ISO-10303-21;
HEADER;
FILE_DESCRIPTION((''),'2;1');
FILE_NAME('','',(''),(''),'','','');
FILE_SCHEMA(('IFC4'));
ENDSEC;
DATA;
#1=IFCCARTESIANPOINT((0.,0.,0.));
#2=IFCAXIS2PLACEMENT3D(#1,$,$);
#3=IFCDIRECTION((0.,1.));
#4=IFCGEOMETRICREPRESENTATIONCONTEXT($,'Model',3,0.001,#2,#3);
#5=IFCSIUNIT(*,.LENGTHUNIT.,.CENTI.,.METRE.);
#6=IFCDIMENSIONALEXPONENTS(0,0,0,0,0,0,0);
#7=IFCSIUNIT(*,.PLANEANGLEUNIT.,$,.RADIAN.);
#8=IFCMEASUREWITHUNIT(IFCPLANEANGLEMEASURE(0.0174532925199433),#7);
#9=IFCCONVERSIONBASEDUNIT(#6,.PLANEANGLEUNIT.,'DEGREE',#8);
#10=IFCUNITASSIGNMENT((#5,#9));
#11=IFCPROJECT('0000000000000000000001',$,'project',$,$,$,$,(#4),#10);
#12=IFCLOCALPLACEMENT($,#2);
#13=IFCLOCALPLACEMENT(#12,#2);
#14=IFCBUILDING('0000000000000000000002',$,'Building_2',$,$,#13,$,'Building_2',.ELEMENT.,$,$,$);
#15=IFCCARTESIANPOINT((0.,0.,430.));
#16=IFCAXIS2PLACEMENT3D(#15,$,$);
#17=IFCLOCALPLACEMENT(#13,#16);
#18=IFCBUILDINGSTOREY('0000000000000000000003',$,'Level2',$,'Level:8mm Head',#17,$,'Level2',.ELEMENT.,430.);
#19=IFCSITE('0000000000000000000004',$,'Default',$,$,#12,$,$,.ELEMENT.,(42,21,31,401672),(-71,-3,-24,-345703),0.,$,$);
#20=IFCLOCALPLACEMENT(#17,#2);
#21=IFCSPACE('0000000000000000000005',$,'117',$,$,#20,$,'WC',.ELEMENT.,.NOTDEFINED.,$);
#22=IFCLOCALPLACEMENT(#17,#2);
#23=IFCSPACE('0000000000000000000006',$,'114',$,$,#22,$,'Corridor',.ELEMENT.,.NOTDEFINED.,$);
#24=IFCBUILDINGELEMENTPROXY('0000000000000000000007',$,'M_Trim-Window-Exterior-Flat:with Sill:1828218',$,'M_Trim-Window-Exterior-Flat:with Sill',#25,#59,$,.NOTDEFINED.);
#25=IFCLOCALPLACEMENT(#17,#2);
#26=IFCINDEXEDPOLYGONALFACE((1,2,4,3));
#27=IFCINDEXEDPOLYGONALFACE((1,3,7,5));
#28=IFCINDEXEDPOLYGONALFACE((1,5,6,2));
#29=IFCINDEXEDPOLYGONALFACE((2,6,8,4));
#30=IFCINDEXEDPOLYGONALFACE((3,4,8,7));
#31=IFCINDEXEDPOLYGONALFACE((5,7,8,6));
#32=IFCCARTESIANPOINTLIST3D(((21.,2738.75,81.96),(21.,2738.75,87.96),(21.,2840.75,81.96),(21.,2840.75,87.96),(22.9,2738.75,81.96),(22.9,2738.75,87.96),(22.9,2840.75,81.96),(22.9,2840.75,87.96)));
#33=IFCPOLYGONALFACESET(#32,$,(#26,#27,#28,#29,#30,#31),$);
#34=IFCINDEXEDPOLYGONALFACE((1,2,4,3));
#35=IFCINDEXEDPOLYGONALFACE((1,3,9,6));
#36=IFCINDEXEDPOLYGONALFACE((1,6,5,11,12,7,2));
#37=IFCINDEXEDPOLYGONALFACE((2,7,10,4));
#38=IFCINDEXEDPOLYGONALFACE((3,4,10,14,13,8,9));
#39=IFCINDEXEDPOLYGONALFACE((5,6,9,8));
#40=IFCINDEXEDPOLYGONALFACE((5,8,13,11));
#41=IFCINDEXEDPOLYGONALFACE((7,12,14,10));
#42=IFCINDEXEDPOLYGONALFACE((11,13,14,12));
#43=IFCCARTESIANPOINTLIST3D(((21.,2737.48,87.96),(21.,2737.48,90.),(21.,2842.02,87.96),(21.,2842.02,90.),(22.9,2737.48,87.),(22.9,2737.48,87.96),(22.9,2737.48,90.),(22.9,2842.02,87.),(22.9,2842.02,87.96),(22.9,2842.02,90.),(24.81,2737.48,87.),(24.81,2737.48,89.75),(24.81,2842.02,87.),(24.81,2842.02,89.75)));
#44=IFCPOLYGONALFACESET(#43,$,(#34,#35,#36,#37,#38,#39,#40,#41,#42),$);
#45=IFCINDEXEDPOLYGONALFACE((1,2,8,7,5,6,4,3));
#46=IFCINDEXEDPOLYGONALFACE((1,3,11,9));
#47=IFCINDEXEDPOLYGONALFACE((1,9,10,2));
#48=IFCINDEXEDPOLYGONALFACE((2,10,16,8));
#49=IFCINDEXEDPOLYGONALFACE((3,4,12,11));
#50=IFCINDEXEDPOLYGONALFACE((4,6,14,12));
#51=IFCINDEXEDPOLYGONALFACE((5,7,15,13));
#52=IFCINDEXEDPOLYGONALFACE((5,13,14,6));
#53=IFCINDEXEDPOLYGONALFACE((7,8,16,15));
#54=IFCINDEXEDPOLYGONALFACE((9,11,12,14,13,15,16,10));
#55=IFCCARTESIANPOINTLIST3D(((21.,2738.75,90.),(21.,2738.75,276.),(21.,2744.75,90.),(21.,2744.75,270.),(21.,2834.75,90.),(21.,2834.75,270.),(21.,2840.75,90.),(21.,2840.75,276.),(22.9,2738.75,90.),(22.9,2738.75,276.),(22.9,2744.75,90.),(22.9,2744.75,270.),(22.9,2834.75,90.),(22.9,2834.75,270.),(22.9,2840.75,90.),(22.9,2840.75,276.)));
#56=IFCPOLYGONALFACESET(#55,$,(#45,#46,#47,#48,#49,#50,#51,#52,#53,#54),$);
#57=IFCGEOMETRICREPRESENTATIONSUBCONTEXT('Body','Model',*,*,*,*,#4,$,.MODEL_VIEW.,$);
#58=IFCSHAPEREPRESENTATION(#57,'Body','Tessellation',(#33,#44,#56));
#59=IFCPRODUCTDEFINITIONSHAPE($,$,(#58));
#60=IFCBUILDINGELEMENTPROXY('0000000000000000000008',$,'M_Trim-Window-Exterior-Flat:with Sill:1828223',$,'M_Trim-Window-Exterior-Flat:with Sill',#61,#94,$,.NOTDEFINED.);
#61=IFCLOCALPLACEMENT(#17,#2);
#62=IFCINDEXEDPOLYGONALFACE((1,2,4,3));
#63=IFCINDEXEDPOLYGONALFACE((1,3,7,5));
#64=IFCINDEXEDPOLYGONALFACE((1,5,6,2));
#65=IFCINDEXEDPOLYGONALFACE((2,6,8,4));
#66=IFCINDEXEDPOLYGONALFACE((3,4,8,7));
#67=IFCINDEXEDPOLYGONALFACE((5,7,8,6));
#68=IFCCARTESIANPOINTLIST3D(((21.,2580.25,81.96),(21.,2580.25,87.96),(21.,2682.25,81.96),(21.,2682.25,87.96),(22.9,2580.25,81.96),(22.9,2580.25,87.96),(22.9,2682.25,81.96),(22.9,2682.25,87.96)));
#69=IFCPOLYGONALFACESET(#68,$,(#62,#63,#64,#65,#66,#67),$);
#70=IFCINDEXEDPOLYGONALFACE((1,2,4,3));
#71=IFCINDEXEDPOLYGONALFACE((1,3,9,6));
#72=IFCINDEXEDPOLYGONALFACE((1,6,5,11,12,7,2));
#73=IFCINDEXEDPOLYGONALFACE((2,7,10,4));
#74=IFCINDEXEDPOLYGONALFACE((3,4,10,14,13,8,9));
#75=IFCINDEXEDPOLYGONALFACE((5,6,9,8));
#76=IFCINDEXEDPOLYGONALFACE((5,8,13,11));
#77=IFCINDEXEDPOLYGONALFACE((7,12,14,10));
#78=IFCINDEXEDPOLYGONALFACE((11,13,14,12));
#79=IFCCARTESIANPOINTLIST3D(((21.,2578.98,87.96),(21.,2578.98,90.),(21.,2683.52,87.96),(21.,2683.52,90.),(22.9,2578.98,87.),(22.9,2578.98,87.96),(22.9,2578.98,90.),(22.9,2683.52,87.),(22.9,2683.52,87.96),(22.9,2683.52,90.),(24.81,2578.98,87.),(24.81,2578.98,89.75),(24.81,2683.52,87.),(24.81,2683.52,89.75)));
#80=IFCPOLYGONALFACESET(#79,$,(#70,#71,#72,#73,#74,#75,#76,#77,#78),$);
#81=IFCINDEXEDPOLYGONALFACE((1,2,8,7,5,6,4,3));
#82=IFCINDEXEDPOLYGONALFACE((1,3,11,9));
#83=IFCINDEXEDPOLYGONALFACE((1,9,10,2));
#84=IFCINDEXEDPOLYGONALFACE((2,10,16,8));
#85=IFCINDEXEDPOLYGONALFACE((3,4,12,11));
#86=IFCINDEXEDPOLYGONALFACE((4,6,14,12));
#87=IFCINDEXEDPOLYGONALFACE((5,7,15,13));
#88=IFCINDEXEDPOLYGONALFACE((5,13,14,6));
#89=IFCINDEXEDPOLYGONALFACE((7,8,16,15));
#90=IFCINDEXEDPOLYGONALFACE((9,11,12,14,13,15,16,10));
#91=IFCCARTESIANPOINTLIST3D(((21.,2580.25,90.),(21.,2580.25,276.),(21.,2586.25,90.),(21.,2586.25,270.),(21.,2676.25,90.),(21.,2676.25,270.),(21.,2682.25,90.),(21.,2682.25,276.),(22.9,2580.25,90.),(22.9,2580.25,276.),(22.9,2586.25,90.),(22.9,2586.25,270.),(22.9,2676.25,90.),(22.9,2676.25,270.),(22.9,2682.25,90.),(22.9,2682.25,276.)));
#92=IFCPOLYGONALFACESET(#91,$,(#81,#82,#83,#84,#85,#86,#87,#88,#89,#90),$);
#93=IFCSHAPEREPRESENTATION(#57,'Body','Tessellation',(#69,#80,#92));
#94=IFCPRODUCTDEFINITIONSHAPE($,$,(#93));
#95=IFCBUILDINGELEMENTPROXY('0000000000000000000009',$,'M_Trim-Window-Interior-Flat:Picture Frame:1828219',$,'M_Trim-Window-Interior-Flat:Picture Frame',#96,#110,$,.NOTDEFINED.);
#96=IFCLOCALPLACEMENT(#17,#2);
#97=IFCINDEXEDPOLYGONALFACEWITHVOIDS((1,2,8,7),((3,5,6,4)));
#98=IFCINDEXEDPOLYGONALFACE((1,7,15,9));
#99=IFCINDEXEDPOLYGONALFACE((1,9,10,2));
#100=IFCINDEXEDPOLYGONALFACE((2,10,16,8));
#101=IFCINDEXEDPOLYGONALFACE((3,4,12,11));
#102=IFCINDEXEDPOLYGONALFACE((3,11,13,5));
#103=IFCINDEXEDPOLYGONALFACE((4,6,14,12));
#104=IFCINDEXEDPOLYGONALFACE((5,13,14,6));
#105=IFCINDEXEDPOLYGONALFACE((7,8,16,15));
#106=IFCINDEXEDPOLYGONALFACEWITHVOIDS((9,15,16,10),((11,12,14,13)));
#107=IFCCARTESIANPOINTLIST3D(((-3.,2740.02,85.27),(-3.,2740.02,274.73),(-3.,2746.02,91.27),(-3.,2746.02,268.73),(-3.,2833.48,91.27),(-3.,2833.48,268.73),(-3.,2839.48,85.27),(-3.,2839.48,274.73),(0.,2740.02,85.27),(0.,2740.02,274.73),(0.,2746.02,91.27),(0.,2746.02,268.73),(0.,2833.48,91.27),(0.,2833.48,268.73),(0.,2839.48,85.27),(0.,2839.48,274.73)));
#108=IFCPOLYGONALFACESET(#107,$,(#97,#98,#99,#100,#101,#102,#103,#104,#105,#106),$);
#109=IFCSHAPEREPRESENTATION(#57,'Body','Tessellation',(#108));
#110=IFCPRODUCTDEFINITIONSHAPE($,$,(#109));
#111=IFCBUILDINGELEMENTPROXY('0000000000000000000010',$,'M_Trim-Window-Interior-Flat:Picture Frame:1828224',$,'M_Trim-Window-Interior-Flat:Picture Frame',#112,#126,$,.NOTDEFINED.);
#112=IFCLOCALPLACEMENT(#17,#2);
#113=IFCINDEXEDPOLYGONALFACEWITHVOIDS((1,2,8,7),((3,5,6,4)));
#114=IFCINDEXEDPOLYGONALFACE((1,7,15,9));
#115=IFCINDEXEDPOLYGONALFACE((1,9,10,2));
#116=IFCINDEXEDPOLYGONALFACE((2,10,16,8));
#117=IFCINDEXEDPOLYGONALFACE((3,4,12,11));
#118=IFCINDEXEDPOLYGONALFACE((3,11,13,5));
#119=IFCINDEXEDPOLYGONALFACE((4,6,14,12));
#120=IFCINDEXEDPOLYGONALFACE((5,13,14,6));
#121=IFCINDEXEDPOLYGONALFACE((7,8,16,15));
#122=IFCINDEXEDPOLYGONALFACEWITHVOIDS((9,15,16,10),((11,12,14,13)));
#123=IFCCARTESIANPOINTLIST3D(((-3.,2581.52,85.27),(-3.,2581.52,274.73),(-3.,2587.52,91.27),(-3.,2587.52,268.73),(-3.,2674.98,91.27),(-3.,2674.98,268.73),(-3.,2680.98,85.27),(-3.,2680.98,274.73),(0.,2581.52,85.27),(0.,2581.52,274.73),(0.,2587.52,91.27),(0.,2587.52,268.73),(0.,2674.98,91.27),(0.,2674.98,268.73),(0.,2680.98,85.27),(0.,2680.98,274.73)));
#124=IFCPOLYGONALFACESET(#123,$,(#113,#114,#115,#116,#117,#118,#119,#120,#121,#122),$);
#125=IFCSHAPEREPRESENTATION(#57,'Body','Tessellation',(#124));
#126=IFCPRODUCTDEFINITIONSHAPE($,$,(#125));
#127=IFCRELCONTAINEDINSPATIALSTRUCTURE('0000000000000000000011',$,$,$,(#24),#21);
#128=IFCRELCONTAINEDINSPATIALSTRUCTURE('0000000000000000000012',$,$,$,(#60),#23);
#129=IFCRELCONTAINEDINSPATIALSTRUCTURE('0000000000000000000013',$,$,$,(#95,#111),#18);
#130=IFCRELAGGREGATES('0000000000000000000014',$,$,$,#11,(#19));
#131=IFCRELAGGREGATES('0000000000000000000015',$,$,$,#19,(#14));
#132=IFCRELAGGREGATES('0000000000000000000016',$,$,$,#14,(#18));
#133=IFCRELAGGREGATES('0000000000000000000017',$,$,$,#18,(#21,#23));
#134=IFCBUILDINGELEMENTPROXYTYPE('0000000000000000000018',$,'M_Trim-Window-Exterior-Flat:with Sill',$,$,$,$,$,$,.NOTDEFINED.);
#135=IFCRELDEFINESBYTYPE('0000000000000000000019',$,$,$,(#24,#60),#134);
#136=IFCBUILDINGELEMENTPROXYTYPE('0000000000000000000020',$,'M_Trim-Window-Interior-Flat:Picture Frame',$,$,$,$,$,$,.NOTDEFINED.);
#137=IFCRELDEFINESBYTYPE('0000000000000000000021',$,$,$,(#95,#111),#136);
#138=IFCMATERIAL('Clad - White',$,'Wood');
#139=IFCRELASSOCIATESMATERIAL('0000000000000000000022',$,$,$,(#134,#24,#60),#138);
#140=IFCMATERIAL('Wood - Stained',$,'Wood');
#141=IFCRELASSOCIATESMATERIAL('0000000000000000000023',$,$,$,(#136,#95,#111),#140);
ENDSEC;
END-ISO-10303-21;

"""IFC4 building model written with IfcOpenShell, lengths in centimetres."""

from ifc_helpers import new_model, entity, si_unit, converted_unit, direction, frame, origin, place, context, subcontext, project, spatial, indexed_curve, outline, extrude, source, transform, mapped, material, type_object, type_shapes, element, save


model = new_model("IFC4")

# Units and contexts
model_context = context("Model", 3, precision=0.001, world=origin(), true_north=direction((0.0, 1.0)))
body_context = subcontext(model_context, "Body", "Model", "MODEL_VIEW")
ifc_project = project(units=[si_unit("LENGTHUNIT", "METRE", prefix="CENTI"), converted_unit("PLANEANGLEUNIT", "DEGREE", entity("IfcPlaneAngleMeasure", 0.0174532925199433), si_unit("PLANEANGLEUNIT", "RADIAN"), dimensions=[0, 0, 0, 0, 0, 0, 0])], contexts=[model_context])

# Site, building, storey
site_placement = place(None, origin())
site = spatial("IfcSite", under=ifc_project, at=site_placement, Name="Default", CompositionType="ELEMENT", RefLatitude=(42, 21, 31, 401672), RefLongitude=(-71, -3, -24, -345703), RefElevation=0.0)
building_placement = place(site_placement, origin())
building = spatial("IfcBuilding", under=site, at=building_placement, Name="Building_2", LongName="Building_2", CompositionType="ELEMENT")
storey_placement = place(building_placement, frame((0.0, 0.0, 430.0)))
storey = spatial("IfcBuildingStorey", under=building, at=storey_placement, Name="Level2", ObjectType="Level:8mm Head", LongName="Level2", CompositionType="ELEMENT", Elevation=430.0)

# Shared definitions
ifc_material_1 = material(Name="Wood - Stained", Category="Wood")

# Shared definitions
ifc_material_2 = material(Name="Clad - White", Category="Wood")

# Shared definitions
space_1_placement = place(storey_placement, origin())
space_1 = spatial("IfcSpace", under=storey, at=space_1_placement, Name="117", LongName="WC", CompositionType="ELEMENT", PredefinedType="NOTDEFINED")

# Building element proxy
building_element_proxy_type_1 = type_object("IfcBuildingElementProxyType", Name="M_Trim-Window-Exterior-Flat:with Sill", PredefinedType="NOTDEFINED", material=ifc_material_2)
shared_shape_1 = source(origin(), body_context, "Body", "SweptSolid", [
    extrude(outline(indexed_curve([(-51.0, -3.0), (51.0, -3.0), (51.0, 3.0), (-51.0, 3.0), (-51.0, -3.0)], self_intersect=False)), frame((0.0, -185.04, 0.0), z_axis=(0.0, 0.0, 1.0), x_axis=(-1.0, 0.0, 0.0)), (0.0, 0.0, 1.0), 1.91),
    extrude(outline(indexed_curve([(-1.9, -1.52), (0.0, -1.52), (0.0, -0.57), (1.9, -0.57), (1.9, 1.48), (0.0, 1.48), (-1.9, 1.23), (-1.9, -1.52)], self_intersect=False)), frame((-52.27, -181.48, 1.9), z_axis=(1.0, 0.0, 0.0), x_axis=(0.0, 0.0, -1.0)), (0.0, 0.0, 1.0), 104.54),
    extrude(outline(indexed_curve([(-94.5, -51.0), (91.5, -51.0), (91.5, -45.0), (-88.5, -45.0), (-88.5, 45.0), (91.5, 45.0), (91.5, 51.0), (-94.5, 51.0), (-94.5, -51.0)], self_intersect=False)), frame((0.0, -88.5, 0.0), z_axis=(0.0, 0.0, 1.0), x_axis=(0.0, -1.0, 0.0)), (0.0, 0.0, 1.0), 1.91),
])
type_shapes(building_element_proxy_type_1, [shared_shape_1])
proxy_1_placement = place(space_1_placement, frame((21.0, 2789.75, 270.0), z_axis=(1.0, 0.0, 0.0), x_axis=(0.0, 1.0, 0.0)))
element("IfcBuildingElementProxy", 1, at=proxy_1_placement, inside=space_1, type_object=building_element_proxy_type_1, material=ifc_material_2, Name="M_Trim-Window-Exterior-Flat:with Sill:1828218", ObjectType="M_Trim-Window-Exterior-Flat:with Sill", PredefinedType="NOTDEFINED", context=body_context, shape_type="MappedRepresentation", body=[
    mapped(shared_shape_1, transform((0.0, 0.0, 0.0), scale=1.0)),
])

# Shared definitions
space_2_placement = place(storey_placement, origin())
space_2 = spatial("IfcSpace", under=storey, at=space_2_placement, Name="114", LongName="Corridor", CompositionType="ELEMENT", PredefinedType="NOTDEFINED")

# Building element proxies
proxy_2_placement = place(space_2_placement, frame((21.0, 2631.25, 270.0), z_axis=(1.0, 0.0, 0.0), x_axis=(0.0, 1.0, 0.0)))
element("IfcBuildingElementProxy", 2, at=proxy_2_placement, inside=space_2, type_object=building_element_proxy_type_1, material=ifc_material_2, Name="M_Trim-Window-Exterior-Flat:with Sill:1828223", ObjectType="M_Trim-Window-Exterior-Flat:with Sill", PredefinedType="NOTDEFINED", context=body_context, shape_type="MappedRepresentation", body=[
    mapped(shared_shape_1, transform((0.0, 0.0, 0.0), scale=1.0)),
])
building_element_proxy_type_2 = type_object("IfcBuildingElementProxyType", Name="M_Trim-Window-Interior-Flat:Picture Frame", PredefinedType="NOTDEFINED", material=ifc_material_1)
shared_shape_2 = source(origin(), body_context, "Body", "SweptSolid", [
    extrude(outline(indexed_curve([(-49.73, -94.73), (49.73, -94.73), (49.73, 94.73), (-49.73, 94.73), (-49.73, -94.73)], self_intersect=False), holes=[indexed_curve([(-43.73, -88.73), (-43.73, 88.73), (43.73, 88.73), (43.73, -88.73), (-43.73, -88.73)], self_intersect=False)]), frame((0.0, -90.0, 0.0), z_axis=(0.0, 0.0, 1.0), x_axis=(-1.0, 0.0, 0.0)), (0.0, 0.0, 1.0), 3.0),
])
type_shapes(building_element_proxy_type_2, [shared_shape_2])
for number, where, z_axis, x_axis, name in (
    (3, (0.0, 2789.75, 270.0), (-1.0, 0.0, 0.0), (0.0, -1.0, 0.0), "M_Trim-Window-Interior-Flat:Picture Frame:1828219"),
    (4, (0.0, 2631.25, 270.0), (-1.0, 0.0, 0.0), (0.0, -1.0, 0.0), "M_Trim-Window-Interior-Flat:Picture Frame:1828224"),
):
    element("IfcBuildingElementProxy", number, at=place(storey_placement, frame(where, z_axis=z_axis, x_axis=x_axis)), inside=storey, type_object=building_element_proxy_type_2, material=ifc_material_1, Name=name, ObjectType="M_Trim-Window-Interior-Flat:Picture Frame", PredefinedType="NOTDEFINED", context=body_context, shape_type="MappedRepresentation", body=[
        mapped(shared_shape_2, transform((0.0, 0.0, 0.0), scale=1.0)),
    ])

save(model, "model.ifc")
